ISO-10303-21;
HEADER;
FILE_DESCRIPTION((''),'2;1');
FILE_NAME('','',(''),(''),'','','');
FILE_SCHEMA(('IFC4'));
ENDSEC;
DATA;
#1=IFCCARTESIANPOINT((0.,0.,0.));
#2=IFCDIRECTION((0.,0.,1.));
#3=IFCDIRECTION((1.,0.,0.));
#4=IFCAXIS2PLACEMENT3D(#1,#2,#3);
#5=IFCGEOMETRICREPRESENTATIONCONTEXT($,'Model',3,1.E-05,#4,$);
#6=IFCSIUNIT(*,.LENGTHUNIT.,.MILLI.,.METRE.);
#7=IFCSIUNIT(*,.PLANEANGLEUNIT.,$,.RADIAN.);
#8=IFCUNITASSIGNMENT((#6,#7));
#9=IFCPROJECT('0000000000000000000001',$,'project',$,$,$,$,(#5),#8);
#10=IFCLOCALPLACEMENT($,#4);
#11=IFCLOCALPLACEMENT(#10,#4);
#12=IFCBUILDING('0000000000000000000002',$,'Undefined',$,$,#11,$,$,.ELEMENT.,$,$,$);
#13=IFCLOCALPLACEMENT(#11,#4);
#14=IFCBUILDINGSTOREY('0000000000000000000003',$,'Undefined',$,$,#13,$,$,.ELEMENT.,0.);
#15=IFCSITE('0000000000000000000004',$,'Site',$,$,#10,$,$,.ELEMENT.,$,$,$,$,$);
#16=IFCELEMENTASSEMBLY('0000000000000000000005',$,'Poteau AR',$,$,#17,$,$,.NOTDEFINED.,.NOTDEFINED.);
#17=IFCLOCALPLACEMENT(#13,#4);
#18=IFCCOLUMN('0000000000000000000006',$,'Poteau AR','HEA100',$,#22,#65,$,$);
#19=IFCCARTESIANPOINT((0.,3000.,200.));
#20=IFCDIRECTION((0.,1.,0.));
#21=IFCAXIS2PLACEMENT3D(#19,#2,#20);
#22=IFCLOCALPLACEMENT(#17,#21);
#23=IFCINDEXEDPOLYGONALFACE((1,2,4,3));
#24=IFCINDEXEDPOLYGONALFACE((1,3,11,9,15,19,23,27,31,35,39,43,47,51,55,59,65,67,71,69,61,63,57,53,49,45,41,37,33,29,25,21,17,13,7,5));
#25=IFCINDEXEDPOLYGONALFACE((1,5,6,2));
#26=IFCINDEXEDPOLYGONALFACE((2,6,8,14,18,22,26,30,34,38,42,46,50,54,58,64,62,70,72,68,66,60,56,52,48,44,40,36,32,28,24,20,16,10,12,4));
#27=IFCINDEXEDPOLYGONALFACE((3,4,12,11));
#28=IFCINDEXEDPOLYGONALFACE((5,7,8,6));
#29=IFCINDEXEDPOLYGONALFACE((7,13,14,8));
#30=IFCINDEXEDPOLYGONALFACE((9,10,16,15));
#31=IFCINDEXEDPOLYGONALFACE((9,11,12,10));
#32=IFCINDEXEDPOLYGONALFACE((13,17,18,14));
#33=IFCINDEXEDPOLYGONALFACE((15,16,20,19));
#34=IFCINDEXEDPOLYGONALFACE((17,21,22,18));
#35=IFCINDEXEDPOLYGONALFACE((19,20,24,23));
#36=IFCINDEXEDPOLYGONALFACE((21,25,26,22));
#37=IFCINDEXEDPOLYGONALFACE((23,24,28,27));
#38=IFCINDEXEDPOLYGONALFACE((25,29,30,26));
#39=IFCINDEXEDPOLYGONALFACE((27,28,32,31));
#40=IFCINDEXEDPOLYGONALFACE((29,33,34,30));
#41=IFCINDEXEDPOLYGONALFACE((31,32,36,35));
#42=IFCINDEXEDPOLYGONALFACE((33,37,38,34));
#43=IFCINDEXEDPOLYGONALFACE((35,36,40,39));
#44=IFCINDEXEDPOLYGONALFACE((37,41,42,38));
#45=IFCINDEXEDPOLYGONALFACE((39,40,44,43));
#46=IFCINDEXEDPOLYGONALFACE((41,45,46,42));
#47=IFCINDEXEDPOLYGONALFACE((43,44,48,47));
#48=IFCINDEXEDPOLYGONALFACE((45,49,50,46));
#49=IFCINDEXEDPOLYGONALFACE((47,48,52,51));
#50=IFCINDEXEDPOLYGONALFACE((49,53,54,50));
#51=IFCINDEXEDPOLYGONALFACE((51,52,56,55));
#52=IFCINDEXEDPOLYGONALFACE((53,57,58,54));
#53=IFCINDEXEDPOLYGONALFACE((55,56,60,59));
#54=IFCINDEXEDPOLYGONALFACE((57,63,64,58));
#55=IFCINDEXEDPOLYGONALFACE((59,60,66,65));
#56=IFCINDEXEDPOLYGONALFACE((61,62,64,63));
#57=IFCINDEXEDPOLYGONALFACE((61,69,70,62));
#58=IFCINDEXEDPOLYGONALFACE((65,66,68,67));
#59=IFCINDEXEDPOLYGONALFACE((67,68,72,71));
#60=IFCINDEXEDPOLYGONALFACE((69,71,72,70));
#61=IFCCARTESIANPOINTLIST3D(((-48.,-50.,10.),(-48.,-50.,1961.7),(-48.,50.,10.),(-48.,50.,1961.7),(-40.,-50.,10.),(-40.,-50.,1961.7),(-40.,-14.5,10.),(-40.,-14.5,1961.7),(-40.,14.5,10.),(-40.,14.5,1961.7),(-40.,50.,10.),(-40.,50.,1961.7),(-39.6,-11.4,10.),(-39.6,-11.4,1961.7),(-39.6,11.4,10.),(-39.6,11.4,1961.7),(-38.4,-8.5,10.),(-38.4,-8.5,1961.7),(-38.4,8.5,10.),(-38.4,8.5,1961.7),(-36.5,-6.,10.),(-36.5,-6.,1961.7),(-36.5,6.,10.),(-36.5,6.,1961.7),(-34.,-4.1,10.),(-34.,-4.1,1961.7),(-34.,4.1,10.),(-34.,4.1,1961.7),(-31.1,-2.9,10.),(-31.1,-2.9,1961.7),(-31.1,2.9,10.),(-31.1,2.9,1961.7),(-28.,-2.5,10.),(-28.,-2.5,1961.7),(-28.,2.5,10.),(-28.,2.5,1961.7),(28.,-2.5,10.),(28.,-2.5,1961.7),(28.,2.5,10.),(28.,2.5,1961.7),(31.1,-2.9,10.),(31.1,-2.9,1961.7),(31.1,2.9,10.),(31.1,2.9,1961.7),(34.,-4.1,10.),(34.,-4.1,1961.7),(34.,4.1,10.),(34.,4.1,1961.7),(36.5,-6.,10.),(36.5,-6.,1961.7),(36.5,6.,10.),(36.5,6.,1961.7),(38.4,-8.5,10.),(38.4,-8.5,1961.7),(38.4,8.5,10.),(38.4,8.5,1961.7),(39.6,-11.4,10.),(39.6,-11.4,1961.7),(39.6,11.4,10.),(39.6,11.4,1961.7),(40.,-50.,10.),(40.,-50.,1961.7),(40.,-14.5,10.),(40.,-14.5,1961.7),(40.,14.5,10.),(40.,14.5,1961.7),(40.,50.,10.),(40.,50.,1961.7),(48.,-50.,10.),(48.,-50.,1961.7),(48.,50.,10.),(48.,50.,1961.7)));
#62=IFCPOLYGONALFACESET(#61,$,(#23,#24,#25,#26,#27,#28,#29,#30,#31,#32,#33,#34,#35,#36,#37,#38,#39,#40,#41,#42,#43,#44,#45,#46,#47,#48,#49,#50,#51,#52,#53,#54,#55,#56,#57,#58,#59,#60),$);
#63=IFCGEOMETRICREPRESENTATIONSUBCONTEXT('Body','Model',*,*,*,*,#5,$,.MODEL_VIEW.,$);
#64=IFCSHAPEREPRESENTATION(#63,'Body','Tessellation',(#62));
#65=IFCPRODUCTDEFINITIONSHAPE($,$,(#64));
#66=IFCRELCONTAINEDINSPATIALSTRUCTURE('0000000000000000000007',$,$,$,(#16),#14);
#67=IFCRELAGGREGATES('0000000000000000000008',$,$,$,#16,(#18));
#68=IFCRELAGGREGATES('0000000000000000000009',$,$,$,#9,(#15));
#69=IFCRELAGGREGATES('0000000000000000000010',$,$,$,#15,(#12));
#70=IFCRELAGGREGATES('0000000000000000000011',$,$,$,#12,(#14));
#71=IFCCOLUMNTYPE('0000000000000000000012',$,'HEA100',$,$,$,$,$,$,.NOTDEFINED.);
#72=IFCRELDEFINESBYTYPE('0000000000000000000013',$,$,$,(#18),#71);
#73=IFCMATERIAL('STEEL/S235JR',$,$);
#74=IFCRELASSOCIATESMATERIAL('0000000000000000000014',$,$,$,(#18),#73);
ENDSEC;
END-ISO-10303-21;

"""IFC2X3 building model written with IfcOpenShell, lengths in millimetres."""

from ifc_helpers import new_model, si_unit, frame, origin_with_axes, origin_2d_with_axis, place, context, subcontext, project, spatial, i_section, extrude, clip, halfspace, material, type_object, element, aggregate, save


model = new_model("IFC2X3")

# Units and contexts
model_context = context("Model", 3, precision=1e-05, world=origin_with_axes())
body_context = subcontext(model_context, "Body", "Model", "MODEL_VIEW")
ifc_project = project(units=[si_unit("LENGTHUNIT", "METRE", prefix="MILLI"), si_unit("PLANEANGLEUNIT", "RADIAN")], contexts=[model_context])

# Site, building, storey
site_placement = place(None, origin_with_axes())
site = spatial("IfcSite", under=ifc_project, at=site_placement, Name="Site", CompositionType="ELEMENT")
building_placement = place(site_placement, origin_with_axes())
building = spatial("IfcBuilding", under=site, at=building_placement, Name="Undefined", CompositionType="ELEMENT")
storey_placement = place(building_placement, origin_with_axes())
storey = spatial("IfcBuildingStorey", under=building, at=storey_placement, Name="Undefined", CompositionType="ELEMENT", Elevation=0.0)

# Element assembly, column
ifc_material_1 = material(Name="STEEL/S235JR")
assembly_1_placement = place(storey_placement, origin_with_axes())
assembly_1 = element("IfcElementAssembly", 1, at=assembly_1_placement, inside=storey, Name="Poteau AR", AssemblyPlace="NOTDEFINED", PredefinedType="NOTDEFINED")
column_type_1 = type_object("IfcColumnType", Name="HEA100", PredefinedType="NOTDEFINED")
column_1_placement = place(assembly_1_placement, frame((0.0, 3000.0, 200.0), z_axis=(0.0, 0.0, 1.0), x_axis=(0.0, 1.0, 0.0)))
column_1 = element("IfcColumn", 2, at=column_1_placement, type_object=column_type_1, material=ifc_material_1, Name="Poteau AR", Description="HEA100", context=body_context, shape_type="Clipping", body=[
    clip(clip(extrude(i_section(OverallWidth=100.0, OverallDepth=96.0, WebThickness=5.0, FlangeThickness=8.0, FilletRadius=12.0, at=origin_2d_with_axis()), frame((0.0, 0.0, 2000.0), z_axis=(0.0, 0.0, -1.0), x_axis=(0.0, 1.0, 0.0)), (0.0, 0.0, 1.0), 2000.0), halfspace(frame((48.0, 0.0, 1961.7), z_axis=(0.0, 0.0, -1.0), x_axis=(0.0, 1.0, 0.0)), True)), halfspace(frame((-48.0, 0.0, 10.0), z_axis=(0.0, 0.0, 1.0), x_axis=(0.0, 1.0, 0.0)), True)),
])

aggregate(assembly_1, [column_1])

save(model, "model.ifc")
